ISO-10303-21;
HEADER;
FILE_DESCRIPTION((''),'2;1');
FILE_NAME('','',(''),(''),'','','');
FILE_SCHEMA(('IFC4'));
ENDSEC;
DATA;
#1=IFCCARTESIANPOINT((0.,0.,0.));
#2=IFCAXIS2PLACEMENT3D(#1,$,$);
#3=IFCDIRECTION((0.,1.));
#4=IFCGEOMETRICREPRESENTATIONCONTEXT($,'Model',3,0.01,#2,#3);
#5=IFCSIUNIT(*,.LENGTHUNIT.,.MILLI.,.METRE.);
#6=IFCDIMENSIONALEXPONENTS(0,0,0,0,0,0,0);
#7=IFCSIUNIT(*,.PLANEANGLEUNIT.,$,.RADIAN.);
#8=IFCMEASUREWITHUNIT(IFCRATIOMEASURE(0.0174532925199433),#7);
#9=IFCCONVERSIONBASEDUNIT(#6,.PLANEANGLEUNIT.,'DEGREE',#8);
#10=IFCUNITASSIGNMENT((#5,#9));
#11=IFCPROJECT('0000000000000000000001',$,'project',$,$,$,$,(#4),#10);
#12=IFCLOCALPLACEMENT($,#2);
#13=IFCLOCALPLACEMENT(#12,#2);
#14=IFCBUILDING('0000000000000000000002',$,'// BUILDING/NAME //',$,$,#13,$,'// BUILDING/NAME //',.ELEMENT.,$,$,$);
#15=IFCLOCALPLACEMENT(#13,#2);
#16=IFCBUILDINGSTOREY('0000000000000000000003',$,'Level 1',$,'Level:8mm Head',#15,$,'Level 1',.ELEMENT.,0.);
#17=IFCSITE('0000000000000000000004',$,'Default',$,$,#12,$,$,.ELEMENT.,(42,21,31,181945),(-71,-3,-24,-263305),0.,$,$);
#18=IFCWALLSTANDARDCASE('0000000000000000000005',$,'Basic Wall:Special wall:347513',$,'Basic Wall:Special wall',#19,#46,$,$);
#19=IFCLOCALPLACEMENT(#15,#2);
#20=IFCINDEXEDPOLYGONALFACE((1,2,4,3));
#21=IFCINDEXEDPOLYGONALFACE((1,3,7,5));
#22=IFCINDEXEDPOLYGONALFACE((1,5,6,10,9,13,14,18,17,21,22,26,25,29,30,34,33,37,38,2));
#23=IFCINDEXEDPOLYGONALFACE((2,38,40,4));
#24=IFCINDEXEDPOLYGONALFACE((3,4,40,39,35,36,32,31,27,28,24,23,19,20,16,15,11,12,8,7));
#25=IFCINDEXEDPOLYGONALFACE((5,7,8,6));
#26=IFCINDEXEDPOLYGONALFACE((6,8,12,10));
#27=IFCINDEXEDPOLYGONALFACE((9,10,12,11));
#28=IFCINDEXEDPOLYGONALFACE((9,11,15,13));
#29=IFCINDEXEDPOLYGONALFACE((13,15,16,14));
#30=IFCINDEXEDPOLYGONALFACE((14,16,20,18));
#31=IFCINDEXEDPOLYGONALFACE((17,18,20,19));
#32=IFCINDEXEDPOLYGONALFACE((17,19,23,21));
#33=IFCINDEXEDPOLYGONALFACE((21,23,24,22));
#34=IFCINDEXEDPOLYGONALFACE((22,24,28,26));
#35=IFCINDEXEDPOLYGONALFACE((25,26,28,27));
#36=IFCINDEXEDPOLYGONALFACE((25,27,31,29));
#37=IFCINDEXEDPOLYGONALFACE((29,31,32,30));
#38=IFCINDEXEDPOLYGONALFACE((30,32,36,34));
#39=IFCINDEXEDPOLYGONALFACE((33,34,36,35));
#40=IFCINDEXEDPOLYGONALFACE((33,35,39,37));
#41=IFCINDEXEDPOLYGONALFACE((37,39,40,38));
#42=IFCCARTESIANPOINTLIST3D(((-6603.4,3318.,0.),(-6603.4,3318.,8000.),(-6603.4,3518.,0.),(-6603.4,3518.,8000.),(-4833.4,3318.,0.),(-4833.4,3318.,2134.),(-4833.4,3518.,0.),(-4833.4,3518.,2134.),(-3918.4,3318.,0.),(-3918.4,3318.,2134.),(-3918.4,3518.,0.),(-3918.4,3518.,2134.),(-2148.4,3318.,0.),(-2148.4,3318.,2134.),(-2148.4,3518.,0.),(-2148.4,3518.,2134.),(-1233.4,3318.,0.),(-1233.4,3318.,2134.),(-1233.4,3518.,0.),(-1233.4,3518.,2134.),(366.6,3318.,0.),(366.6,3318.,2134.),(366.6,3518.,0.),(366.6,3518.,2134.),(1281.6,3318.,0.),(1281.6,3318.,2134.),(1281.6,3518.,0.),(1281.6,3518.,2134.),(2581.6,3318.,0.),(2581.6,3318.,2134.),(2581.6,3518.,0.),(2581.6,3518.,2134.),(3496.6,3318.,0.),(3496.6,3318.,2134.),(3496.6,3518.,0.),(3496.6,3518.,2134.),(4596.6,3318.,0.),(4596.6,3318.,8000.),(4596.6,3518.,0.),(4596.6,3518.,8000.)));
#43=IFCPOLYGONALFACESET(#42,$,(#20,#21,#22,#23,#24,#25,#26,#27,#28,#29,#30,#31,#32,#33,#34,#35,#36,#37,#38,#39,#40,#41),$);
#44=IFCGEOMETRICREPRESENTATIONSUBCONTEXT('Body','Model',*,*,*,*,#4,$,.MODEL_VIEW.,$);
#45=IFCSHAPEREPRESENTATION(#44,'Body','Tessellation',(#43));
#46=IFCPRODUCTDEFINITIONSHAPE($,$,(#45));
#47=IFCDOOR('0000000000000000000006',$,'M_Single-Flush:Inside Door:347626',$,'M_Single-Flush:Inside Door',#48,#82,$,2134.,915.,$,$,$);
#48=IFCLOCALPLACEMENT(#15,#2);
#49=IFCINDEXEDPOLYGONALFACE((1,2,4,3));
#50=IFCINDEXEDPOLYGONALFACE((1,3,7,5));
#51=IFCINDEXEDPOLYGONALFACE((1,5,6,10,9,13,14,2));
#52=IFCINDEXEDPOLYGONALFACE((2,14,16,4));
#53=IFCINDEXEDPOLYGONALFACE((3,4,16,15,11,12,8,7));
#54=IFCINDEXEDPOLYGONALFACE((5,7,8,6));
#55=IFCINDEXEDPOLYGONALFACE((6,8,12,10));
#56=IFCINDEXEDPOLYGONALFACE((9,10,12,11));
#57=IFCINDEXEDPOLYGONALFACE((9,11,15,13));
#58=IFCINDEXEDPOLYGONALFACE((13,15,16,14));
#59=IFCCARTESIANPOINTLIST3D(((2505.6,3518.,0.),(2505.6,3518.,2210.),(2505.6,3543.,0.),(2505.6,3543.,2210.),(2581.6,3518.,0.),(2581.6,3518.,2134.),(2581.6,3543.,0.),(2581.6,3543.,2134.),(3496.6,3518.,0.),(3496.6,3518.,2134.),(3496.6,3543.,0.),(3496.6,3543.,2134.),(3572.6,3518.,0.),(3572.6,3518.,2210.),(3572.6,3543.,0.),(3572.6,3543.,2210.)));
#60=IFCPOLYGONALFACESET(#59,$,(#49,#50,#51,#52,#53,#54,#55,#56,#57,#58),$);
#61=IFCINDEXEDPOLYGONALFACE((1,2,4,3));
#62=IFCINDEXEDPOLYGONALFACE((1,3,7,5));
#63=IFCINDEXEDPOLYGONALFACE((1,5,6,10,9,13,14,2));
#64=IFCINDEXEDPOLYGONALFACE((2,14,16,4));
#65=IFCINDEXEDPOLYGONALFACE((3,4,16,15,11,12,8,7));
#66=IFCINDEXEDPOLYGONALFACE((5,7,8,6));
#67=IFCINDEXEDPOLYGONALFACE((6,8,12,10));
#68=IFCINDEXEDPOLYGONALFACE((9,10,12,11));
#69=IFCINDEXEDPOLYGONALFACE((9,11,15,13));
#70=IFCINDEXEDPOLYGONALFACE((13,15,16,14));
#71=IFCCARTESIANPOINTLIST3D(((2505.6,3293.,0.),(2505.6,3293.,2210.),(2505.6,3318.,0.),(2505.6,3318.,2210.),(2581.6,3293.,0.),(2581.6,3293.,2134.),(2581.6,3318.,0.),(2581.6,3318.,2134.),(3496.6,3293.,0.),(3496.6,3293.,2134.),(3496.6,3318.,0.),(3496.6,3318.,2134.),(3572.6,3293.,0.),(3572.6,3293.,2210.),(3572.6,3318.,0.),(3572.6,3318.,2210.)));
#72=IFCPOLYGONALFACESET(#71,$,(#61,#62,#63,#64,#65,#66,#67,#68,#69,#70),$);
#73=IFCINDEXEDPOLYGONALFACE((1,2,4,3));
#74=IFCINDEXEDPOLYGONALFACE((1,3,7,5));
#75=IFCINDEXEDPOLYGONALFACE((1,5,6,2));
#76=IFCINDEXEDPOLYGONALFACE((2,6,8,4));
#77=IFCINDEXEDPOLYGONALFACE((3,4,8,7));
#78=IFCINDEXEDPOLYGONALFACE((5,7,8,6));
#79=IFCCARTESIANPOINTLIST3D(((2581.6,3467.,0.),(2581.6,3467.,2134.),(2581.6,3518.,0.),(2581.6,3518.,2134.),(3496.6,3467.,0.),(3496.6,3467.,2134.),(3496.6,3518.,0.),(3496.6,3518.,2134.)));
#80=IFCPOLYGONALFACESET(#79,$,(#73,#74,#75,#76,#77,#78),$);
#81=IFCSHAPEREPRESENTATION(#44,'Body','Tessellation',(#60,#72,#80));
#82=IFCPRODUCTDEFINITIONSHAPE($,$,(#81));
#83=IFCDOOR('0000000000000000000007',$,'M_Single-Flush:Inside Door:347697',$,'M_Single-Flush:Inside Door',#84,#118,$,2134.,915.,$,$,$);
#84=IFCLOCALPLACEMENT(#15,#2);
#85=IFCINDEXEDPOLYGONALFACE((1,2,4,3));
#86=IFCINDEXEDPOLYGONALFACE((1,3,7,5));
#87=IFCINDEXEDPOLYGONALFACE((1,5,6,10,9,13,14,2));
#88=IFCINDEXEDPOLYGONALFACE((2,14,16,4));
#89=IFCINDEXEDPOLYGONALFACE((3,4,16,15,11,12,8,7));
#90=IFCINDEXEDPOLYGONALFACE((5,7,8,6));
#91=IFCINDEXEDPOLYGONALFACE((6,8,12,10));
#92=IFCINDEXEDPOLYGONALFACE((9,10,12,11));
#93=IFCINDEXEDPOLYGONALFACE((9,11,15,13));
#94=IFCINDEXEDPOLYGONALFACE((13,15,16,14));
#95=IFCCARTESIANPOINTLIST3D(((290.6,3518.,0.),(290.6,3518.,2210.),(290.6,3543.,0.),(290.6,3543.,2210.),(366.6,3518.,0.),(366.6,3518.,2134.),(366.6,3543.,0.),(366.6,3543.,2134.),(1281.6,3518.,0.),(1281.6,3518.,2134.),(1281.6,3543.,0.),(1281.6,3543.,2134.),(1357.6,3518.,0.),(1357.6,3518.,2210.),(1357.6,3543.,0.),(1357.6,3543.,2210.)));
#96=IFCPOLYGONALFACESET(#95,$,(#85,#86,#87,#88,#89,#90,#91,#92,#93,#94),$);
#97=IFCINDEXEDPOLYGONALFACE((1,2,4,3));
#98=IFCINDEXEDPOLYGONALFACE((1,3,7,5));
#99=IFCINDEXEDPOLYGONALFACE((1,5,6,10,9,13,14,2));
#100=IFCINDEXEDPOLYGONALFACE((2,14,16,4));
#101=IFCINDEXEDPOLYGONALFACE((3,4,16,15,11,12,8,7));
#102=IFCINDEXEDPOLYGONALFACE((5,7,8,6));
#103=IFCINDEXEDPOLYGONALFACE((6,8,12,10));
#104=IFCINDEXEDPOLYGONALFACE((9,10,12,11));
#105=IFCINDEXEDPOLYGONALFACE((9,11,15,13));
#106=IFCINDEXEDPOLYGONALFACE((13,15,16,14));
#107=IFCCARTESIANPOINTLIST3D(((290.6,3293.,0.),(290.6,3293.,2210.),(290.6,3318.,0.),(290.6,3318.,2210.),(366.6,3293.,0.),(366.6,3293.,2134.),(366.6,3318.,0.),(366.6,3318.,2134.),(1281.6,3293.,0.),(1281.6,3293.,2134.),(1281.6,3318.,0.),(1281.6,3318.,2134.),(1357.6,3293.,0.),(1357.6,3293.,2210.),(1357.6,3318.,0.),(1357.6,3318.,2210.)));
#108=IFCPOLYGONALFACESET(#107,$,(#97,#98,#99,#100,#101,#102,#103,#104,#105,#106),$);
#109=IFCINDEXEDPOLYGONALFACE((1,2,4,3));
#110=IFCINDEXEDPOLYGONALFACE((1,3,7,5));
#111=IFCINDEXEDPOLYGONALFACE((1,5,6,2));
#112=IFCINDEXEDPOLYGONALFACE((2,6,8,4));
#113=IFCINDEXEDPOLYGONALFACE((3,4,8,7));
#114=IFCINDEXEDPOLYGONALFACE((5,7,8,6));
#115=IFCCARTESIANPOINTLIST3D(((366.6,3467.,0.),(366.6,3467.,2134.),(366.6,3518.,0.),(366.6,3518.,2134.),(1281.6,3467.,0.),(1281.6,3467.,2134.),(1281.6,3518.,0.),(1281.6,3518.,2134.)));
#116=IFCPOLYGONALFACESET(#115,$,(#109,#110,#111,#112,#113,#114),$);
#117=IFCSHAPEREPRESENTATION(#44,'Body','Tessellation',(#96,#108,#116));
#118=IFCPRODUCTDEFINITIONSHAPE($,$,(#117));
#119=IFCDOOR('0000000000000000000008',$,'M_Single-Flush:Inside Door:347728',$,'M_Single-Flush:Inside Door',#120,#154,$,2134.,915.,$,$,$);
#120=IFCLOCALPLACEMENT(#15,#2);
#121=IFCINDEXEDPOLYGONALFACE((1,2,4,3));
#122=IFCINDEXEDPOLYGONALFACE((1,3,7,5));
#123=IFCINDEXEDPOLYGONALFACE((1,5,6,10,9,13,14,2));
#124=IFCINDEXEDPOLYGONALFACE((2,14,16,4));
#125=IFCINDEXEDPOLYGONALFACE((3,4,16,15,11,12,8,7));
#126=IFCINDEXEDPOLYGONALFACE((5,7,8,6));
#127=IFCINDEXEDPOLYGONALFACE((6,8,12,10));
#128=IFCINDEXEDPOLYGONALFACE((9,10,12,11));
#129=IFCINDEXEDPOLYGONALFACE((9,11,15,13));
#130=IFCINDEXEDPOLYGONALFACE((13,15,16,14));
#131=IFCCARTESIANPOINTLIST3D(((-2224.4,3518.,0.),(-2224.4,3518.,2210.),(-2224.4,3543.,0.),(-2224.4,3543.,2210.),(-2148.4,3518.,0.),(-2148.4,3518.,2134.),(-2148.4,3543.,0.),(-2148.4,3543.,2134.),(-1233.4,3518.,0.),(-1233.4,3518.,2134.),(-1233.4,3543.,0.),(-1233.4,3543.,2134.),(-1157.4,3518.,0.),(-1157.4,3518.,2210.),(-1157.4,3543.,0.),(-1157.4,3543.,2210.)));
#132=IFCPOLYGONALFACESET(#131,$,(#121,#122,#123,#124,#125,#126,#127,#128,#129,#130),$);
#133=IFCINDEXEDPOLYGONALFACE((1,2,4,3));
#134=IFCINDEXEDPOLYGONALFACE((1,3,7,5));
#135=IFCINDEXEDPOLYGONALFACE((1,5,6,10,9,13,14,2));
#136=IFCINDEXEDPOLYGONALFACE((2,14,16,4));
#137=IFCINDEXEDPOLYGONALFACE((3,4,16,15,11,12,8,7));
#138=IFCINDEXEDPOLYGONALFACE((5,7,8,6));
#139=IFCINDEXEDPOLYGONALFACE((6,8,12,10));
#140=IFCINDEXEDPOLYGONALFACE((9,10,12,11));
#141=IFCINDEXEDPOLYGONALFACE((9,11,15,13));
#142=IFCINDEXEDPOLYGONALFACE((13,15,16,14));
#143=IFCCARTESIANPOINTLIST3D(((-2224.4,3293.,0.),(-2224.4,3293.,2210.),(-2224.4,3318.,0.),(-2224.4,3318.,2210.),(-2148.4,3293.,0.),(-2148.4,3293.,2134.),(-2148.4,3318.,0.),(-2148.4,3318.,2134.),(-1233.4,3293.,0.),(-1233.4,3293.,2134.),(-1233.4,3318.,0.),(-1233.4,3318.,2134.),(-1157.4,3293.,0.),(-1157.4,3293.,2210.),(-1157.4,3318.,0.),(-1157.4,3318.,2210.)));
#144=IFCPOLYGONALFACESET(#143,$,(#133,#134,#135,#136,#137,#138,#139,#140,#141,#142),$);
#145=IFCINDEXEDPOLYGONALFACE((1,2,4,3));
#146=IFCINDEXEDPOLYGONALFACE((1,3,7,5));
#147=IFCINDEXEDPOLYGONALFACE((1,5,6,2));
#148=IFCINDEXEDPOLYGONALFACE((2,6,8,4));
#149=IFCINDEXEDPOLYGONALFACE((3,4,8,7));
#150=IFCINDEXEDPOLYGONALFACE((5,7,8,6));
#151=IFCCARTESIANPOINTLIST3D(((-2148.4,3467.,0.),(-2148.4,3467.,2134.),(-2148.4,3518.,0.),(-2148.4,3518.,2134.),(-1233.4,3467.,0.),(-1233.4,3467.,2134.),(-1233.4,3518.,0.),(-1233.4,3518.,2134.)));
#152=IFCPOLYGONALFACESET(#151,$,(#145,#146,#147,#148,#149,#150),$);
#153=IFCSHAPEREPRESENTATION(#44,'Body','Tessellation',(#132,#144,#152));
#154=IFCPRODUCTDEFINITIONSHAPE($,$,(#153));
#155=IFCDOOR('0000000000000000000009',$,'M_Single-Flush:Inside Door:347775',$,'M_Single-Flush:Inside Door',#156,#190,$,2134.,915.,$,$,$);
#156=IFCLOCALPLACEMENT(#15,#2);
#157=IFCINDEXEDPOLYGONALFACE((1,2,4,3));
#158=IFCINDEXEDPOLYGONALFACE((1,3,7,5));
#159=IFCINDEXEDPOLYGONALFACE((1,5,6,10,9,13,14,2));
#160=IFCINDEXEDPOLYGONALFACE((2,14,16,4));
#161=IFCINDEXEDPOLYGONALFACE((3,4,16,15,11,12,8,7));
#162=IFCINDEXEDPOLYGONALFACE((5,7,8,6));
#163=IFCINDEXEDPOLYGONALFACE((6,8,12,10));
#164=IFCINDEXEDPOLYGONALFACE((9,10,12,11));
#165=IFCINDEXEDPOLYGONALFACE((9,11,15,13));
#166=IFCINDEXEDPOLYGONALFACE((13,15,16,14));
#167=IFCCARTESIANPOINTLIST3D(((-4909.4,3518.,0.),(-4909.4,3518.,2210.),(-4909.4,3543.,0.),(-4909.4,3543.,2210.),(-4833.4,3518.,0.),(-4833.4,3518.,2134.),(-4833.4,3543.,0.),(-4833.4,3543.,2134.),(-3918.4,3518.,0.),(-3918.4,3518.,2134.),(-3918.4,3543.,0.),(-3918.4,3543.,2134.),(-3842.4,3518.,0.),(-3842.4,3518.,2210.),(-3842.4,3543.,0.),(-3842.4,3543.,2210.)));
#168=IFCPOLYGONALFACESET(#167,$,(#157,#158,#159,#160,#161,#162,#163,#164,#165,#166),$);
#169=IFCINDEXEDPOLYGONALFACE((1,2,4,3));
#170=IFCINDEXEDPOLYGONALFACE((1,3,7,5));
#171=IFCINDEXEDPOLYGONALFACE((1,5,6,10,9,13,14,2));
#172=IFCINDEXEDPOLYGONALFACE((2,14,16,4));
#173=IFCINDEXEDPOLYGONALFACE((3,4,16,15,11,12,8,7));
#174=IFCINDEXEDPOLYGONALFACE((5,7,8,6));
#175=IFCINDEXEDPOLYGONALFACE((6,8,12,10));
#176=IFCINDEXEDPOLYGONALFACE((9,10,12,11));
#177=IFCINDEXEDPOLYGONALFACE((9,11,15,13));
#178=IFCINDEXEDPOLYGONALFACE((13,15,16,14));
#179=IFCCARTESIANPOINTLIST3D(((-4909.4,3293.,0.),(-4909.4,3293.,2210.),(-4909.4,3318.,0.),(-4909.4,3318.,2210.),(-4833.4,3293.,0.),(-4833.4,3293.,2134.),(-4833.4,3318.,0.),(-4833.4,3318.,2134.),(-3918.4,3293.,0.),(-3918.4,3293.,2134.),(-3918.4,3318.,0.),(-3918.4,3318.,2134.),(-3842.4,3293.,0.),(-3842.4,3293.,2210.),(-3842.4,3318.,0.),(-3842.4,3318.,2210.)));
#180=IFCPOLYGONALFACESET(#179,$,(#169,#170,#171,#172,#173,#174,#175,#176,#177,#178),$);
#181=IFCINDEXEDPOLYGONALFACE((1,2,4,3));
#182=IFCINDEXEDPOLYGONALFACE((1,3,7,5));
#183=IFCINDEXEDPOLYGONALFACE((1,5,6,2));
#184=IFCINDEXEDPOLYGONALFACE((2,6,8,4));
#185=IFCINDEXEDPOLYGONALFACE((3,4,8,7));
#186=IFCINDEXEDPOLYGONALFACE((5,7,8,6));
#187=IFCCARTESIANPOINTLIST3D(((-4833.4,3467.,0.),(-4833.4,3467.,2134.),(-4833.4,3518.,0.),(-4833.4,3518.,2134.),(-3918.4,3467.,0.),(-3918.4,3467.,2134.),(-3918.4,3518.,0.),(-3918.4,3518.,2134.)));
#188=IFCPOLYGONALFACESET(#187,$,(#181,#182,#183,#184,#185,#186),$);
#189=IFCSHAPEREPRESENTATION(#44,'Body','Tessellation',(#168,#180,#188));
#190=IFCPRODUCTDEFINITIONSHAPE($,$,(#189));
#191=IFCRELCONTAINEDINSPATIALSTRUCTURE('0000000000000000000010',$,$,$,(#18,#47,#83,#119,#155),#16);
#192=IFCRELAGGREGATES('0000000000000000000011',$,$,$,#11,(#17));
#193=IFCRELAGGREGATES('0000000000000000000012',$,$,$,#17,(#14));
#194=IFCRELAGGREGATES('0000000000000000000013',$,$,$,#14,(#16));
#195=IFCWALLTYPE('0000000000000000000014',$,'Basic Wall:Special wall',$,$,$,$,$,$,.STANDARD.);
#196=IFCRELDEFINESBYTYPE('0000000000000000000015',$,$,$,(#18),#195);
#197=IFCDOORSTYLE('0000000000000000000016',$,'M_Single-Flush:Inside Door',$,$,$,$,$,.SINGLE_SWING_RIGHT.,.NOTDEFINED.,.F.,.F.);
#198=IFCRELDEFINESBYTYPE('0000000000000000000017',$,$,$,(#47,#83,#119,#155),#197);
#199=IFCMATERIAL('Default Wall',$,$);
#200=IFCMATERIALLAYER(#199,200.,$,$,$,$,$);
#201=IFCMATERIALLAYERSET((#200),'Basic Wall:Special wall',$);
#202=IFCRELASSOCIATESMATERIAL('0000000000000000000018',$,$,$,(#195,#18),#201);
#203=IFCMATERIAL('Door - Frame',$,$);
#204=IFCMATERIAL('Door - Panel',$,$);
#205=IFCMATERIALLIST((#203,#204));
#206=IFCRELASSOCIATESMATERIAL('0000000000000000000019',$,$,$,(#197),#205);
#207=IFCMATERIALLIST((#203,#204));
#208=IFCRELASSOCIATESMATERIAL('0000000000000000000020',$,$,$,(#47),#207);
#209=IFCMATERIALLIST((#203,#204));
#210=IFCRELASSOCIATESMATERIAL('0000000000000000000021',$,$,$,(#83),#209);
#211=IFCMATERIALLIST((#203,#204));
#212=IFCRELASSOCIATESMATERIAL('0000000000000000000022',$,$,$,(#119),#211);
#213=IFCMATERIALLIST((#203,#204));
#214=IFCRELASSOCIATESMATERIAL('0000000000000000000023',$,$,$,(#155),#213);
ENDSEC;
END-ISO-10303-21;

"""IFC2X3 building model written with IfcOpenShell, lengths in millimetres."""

from ifc_helpers import new_model, entity, si_unit, converted_unit, direction, frame, frame_2d, origin, place, context, subcontext, project, spatial, polyline, rectangle, outline, extrude, source, transform, mapped, material, material_list, layer, layer_set, layer_usage, type_object, type_shapes, element, fill, save


model = new_model("IFC2X3")

# Units and contexts
model_context = context("Model", 3, precision=0.01, world=origin(), true_north=direction((0.0, 1.0)))
body_context = subcontext(model_context, "Body", "Model", "MODEL_VIEW")
ifc_project = project(units=[si_unit("LENGTHUNIT", "METRE", prefix="MILLI"), converted_unit("PLANEANGLEUNIT", "DEGREE", entity("IfcRatioMeasure", 0.0174532925199433), si_unit("PLANEANGLEUNIT", "RADIAN"), dimensions=[0, 0, 0, 0, 0, 0, 0])], contexts=[model_context])

# Site, building, storey
site_placement = place(None, origin())
site = spatial("IfcSite", under=ifc_project, at=site_placement, Name="Default", CompositionType="ELEMENT", RefLatitude=(42, 21, 31, 181945), RefLongitude=(-71, -3, -24, -263305), RefElevation=0.0)
building_placement = place(site_placement, origin())
building = spatial("IfcBuilding", under=site, at=building_placement, Name="// BUILDING/NAME //", LongName="// BUILDING/NAME //", CompositionType="ELEMENT")
storey_placement = place(building_placement, origin())
storey = spatial("IfcBuildingStorey", under=building, at=storey_placement, Name="Level 1", ObjectType="Level:8mm Head", LongName="Level 1", CompositionType="ELEMENT", Elevation=0.0)

# Wall, openings, doors
ifc_material_1 = material(Name="Default Wall")
ifc_material_2 = material(Name="Door - Frame")
ifc_material_3 = material(Name="Door - Panel")
ifc_layer_1 = layer(ifc_material_1, 200.0)
ifc_layer_set_1 = layer_set([ifc_layer_1], Name="Basic Wall:Special wall")
ifc_layer_usage_1 = layer_usage(ifc_layer_set_1, "AXIS2", "NEGATIVE", 100.0)
wall_type_1 = type_object("IfcWallType", Name="Basic Wall:Special wall", PredefinedType="STANDARD", material=ifc_layer_set_1)
wall_1_placement = place(storey_placement, frame((-6603.4, 3418.0, 0.0)))
wall_1 = element("IfcWallStandardCase", 1, at=wall_1_placement, inside=storey, type_object=wall_type_1, material=ifc_layer_usage_1, Name="Basic Wall:Special wall:347513", ObjectType="Basic Wall:Special wall", context=body_context, shape_type="SweptSolid", body=[
    extrude(rectangle(XDim=11200.0, YDim=200.0, at=frame_2d((5600.0, 0.0), x_axis=(-1.0, 0.0))), origin(), (0.0, 0.0, 1.0), 8000.0),
])
opening_1_placement = place(wall_1_placement, frame((9185.0, -100.0, 0.0)))
opening_1 = element("IfcOpeningElement", 2, at=opening_1_placement, cuts=wall_1, ObjectType="Opening", context=body_context, shape_type="SweptSolid", body=[
    extrude(rectangle(XDim=915.0, YDim=2134.0, at=frame_2d((1067.0, 457.5), x_axis=(0.0, 1.0))), frame((0.0, 0.0, 0.0), z_axis=(0.0, 1.0, 0.0), x_axis=(0.0, 0.0, 1.0)), (0.0, 0.0, 1.0), 200.0),
])
opening_2_placement = place(wall_1_placement, frame((6970.0, -100.0, 0.0)))
opening_2 = element("IfcOpeningElement", 3, at=opening_2_placement, cuts=wall_1, ObjectType="Opening", context=body_context, shape_type="SweptSolid", body=[
    extrude(rectangle(XDim=915.0, YDim=2134.0, at=frame_2d((1067.0, 457.5), x_axis=(0.0, 1.0))), frame((0.0, 0.0, 0.0), z_axis=(0.0, 1.0, 0.0), x_axis=(0.0, 0.0, 1.0)), (0.0, 0.0, 1.0), 200.0),
])
opening_3_placement = place(wall_1_placement, frame((4455.0, -100.0, 0.0)))
opening_3 = element("IfcOpeningElement", 4, at=opening_3_placement, cuts=wall_1, ObjectType="Opening", context=body_context, shape_type="SweptSolid", body=[
    extrude(rectangle(XDim=915.0, YDim=2134.0, at=frame_2d((1067.0, 457.5), x_axis=(0.0, 1.0))), frame((0.0, 0.0, 0.0), z_axis=(0.0, 1.0, 0.0), x_axis=(0.0, 0.0, 1.0)), (0.0, 0.0, 1.0), 200.0),
])
opening_4_placement = place(wall_1_placement, frame((1770.0, -100.0, 0.0)))
opening_4 = element("IfcOpeningElement", 5, at=opening_4_placement, cuts=wall_1, ObjectType="Opening", context=body_context, shape_type="SweptSolid", body=[
    extrude(rectangle(XDim=915.0, YDim=2134.0, at=frame_2d((1067.0, 457.5), x_axis=(0.0, 1.0))), frame((0.0, 0.0, 0.0), z_axis=(0.0, 1.0, 0.0), x_axis=(0.0, 0.0, 1.0)), (0.0, 0.0, 1.0), 200.0),
])
ifc_material_list_1 = material_list([ifc_material_2, ifc_material_3])
ifc_material_list_2 = material_list([ifc_material_2, ifc_material_3])
door_style_1 = type_object("IfcDoorStyle", Name="M_Single-Flush:Inside Door", ConstructionType="NOTDEFINED", OperationType="SINGLE_SWING_RIGHT", ParameterTakesPrecedence=False, Sizeable=False, material=ifc_material_list_2)
shared_shape_1 = source(origin(), body_context, "Body", "SweptSolid", [
    extrude(outline(polyline([(-533.5, -1124.0), (533.5, -1124.0), (533.5, 1086.0), (457.5, 1086.0), (457.5, -1048.0), (-457.5, -1048.0), (-457.5, 1086.0), (-533.5, 1086.0), (-533.5, -1124.0)])), frame((457.5, 200.0, 1086.0), z_axis=(0.0, 1.0, 0.0), x_axis=(1.0, 0.0, 0.0)), (0.0, 0.0, 1.0), 25.0),
    extrude(outline(polyline([(-1124.0, -533.5), (1086.0, -533.5), (1086.0, -457.5), (-1048.0, -457.5), (-1048.0, 457.5), (1086.0, 457.5), (1086.0, 533.5), (-1124.0, 533.5), (-1124.0, -533.5)])), frame((457.5, -25.0, 1086.0), z_axis=(0.0, 1.0, 0.0), x_axis=(0.0, 0.0, -1.0)), (0.0, 0.0, 1.0), 25.0),
    extrude(rectangle(XDim=51.0, YDim=915.0, at=frame_2d((0.0, 0.0), x_axis=(1.0, 0.0))), frame((457.5, 174.5, 0.0), z_axis=(0.0, 0.0, 1.0), x_axis=(0.0, 1.0, 0.0)), (0.0, 0.0, 1.0), 2134.0),
])
type_shapes(door_style_1, [shared_shape_1])
door_1_placement = place(opening_1_placement, origin())
door_1 = element("IfcDoor", 6, at=door_1_placement, inside=storey, type_object=door_style_1, material=ifc_material_list_1, Name="M_Single-Flush:Inside Door:347626", ObjectType="M_Single-Flush:Inside Door", OverallHeight=2134.0, OverallWidth=915.0, context=body_context, shape_type="MappedRepresentation", body=[
    mapped(shared_shape_1, transform((0.0, 0.0, 0.0), scale=1.0)),
])
fill(opening_1, door_1)
ifc_material_list_3 = material_list([ifc_material_2, ifc_material_3])
door_2_placement = place(opening_2_placement, origin())
door_2 = element("IfcDoor", 7, at=door_2_placement, inside=storey, type_object=door_style_1, material=ifc_material_list_3, Name="M_Single-Flush:Inside Door:347697", ObjectType="M_Single-Flush:Inside Door", OverallHeight=2134.0, OverallWidth=915.0, context=body_context, shape_type="MappedRepresentation", body=[
    mapped(shared_shape_1, transform((0.0, 0.0, 0.0), scale=1.0)),
])
fill(opening_2, door_2)
ifc_material_list_4 = material_list([ifc_material_2, ifc_material_3])
door_3_placement = place(opening_3_placement, origin())
door_3 = element("IfcDoor", 8, at=door_3_placement, inside=storey, type_object=door_style_1, material=ifc_material_list_4, Name="M_Single-Flush:Inside Door:347728", ObjectType="M_Single-Flush:Inside Door", OverallHeight=2134.0, OverallWidth=915.0, context=body_context, shape_type="MappedRepresentation", body=[
    mapped(shared_shape_1, transform((0.0, 0.0, 0.0), scale=1.0)),
])
fill(opening_3, door_3)
ifc_material_list_5 = material_list([ifc_material_2, ifc_material_3])
door_4_placement = place(opening_4_placement, origin())
door_4 = element("IfcDoor", 9, at=door_4_placement, inside=storey, type_object=door_style_1, material=ifc_material_list_5, Name="M_Single-Flush:Inside Door:347775", ObjectType="M_Single-Flush:Inside Door", OverallHeight=2134.0, OverallWidth=915.0, context=body_context, shape_type="MappedRepresentation", body=[
    mapped(shared_shape_1, transform((0.0, 0.0, 0.0), scale=1.0)),
])
fill(opening_4, door_4)

save(model, "model.ifc")
